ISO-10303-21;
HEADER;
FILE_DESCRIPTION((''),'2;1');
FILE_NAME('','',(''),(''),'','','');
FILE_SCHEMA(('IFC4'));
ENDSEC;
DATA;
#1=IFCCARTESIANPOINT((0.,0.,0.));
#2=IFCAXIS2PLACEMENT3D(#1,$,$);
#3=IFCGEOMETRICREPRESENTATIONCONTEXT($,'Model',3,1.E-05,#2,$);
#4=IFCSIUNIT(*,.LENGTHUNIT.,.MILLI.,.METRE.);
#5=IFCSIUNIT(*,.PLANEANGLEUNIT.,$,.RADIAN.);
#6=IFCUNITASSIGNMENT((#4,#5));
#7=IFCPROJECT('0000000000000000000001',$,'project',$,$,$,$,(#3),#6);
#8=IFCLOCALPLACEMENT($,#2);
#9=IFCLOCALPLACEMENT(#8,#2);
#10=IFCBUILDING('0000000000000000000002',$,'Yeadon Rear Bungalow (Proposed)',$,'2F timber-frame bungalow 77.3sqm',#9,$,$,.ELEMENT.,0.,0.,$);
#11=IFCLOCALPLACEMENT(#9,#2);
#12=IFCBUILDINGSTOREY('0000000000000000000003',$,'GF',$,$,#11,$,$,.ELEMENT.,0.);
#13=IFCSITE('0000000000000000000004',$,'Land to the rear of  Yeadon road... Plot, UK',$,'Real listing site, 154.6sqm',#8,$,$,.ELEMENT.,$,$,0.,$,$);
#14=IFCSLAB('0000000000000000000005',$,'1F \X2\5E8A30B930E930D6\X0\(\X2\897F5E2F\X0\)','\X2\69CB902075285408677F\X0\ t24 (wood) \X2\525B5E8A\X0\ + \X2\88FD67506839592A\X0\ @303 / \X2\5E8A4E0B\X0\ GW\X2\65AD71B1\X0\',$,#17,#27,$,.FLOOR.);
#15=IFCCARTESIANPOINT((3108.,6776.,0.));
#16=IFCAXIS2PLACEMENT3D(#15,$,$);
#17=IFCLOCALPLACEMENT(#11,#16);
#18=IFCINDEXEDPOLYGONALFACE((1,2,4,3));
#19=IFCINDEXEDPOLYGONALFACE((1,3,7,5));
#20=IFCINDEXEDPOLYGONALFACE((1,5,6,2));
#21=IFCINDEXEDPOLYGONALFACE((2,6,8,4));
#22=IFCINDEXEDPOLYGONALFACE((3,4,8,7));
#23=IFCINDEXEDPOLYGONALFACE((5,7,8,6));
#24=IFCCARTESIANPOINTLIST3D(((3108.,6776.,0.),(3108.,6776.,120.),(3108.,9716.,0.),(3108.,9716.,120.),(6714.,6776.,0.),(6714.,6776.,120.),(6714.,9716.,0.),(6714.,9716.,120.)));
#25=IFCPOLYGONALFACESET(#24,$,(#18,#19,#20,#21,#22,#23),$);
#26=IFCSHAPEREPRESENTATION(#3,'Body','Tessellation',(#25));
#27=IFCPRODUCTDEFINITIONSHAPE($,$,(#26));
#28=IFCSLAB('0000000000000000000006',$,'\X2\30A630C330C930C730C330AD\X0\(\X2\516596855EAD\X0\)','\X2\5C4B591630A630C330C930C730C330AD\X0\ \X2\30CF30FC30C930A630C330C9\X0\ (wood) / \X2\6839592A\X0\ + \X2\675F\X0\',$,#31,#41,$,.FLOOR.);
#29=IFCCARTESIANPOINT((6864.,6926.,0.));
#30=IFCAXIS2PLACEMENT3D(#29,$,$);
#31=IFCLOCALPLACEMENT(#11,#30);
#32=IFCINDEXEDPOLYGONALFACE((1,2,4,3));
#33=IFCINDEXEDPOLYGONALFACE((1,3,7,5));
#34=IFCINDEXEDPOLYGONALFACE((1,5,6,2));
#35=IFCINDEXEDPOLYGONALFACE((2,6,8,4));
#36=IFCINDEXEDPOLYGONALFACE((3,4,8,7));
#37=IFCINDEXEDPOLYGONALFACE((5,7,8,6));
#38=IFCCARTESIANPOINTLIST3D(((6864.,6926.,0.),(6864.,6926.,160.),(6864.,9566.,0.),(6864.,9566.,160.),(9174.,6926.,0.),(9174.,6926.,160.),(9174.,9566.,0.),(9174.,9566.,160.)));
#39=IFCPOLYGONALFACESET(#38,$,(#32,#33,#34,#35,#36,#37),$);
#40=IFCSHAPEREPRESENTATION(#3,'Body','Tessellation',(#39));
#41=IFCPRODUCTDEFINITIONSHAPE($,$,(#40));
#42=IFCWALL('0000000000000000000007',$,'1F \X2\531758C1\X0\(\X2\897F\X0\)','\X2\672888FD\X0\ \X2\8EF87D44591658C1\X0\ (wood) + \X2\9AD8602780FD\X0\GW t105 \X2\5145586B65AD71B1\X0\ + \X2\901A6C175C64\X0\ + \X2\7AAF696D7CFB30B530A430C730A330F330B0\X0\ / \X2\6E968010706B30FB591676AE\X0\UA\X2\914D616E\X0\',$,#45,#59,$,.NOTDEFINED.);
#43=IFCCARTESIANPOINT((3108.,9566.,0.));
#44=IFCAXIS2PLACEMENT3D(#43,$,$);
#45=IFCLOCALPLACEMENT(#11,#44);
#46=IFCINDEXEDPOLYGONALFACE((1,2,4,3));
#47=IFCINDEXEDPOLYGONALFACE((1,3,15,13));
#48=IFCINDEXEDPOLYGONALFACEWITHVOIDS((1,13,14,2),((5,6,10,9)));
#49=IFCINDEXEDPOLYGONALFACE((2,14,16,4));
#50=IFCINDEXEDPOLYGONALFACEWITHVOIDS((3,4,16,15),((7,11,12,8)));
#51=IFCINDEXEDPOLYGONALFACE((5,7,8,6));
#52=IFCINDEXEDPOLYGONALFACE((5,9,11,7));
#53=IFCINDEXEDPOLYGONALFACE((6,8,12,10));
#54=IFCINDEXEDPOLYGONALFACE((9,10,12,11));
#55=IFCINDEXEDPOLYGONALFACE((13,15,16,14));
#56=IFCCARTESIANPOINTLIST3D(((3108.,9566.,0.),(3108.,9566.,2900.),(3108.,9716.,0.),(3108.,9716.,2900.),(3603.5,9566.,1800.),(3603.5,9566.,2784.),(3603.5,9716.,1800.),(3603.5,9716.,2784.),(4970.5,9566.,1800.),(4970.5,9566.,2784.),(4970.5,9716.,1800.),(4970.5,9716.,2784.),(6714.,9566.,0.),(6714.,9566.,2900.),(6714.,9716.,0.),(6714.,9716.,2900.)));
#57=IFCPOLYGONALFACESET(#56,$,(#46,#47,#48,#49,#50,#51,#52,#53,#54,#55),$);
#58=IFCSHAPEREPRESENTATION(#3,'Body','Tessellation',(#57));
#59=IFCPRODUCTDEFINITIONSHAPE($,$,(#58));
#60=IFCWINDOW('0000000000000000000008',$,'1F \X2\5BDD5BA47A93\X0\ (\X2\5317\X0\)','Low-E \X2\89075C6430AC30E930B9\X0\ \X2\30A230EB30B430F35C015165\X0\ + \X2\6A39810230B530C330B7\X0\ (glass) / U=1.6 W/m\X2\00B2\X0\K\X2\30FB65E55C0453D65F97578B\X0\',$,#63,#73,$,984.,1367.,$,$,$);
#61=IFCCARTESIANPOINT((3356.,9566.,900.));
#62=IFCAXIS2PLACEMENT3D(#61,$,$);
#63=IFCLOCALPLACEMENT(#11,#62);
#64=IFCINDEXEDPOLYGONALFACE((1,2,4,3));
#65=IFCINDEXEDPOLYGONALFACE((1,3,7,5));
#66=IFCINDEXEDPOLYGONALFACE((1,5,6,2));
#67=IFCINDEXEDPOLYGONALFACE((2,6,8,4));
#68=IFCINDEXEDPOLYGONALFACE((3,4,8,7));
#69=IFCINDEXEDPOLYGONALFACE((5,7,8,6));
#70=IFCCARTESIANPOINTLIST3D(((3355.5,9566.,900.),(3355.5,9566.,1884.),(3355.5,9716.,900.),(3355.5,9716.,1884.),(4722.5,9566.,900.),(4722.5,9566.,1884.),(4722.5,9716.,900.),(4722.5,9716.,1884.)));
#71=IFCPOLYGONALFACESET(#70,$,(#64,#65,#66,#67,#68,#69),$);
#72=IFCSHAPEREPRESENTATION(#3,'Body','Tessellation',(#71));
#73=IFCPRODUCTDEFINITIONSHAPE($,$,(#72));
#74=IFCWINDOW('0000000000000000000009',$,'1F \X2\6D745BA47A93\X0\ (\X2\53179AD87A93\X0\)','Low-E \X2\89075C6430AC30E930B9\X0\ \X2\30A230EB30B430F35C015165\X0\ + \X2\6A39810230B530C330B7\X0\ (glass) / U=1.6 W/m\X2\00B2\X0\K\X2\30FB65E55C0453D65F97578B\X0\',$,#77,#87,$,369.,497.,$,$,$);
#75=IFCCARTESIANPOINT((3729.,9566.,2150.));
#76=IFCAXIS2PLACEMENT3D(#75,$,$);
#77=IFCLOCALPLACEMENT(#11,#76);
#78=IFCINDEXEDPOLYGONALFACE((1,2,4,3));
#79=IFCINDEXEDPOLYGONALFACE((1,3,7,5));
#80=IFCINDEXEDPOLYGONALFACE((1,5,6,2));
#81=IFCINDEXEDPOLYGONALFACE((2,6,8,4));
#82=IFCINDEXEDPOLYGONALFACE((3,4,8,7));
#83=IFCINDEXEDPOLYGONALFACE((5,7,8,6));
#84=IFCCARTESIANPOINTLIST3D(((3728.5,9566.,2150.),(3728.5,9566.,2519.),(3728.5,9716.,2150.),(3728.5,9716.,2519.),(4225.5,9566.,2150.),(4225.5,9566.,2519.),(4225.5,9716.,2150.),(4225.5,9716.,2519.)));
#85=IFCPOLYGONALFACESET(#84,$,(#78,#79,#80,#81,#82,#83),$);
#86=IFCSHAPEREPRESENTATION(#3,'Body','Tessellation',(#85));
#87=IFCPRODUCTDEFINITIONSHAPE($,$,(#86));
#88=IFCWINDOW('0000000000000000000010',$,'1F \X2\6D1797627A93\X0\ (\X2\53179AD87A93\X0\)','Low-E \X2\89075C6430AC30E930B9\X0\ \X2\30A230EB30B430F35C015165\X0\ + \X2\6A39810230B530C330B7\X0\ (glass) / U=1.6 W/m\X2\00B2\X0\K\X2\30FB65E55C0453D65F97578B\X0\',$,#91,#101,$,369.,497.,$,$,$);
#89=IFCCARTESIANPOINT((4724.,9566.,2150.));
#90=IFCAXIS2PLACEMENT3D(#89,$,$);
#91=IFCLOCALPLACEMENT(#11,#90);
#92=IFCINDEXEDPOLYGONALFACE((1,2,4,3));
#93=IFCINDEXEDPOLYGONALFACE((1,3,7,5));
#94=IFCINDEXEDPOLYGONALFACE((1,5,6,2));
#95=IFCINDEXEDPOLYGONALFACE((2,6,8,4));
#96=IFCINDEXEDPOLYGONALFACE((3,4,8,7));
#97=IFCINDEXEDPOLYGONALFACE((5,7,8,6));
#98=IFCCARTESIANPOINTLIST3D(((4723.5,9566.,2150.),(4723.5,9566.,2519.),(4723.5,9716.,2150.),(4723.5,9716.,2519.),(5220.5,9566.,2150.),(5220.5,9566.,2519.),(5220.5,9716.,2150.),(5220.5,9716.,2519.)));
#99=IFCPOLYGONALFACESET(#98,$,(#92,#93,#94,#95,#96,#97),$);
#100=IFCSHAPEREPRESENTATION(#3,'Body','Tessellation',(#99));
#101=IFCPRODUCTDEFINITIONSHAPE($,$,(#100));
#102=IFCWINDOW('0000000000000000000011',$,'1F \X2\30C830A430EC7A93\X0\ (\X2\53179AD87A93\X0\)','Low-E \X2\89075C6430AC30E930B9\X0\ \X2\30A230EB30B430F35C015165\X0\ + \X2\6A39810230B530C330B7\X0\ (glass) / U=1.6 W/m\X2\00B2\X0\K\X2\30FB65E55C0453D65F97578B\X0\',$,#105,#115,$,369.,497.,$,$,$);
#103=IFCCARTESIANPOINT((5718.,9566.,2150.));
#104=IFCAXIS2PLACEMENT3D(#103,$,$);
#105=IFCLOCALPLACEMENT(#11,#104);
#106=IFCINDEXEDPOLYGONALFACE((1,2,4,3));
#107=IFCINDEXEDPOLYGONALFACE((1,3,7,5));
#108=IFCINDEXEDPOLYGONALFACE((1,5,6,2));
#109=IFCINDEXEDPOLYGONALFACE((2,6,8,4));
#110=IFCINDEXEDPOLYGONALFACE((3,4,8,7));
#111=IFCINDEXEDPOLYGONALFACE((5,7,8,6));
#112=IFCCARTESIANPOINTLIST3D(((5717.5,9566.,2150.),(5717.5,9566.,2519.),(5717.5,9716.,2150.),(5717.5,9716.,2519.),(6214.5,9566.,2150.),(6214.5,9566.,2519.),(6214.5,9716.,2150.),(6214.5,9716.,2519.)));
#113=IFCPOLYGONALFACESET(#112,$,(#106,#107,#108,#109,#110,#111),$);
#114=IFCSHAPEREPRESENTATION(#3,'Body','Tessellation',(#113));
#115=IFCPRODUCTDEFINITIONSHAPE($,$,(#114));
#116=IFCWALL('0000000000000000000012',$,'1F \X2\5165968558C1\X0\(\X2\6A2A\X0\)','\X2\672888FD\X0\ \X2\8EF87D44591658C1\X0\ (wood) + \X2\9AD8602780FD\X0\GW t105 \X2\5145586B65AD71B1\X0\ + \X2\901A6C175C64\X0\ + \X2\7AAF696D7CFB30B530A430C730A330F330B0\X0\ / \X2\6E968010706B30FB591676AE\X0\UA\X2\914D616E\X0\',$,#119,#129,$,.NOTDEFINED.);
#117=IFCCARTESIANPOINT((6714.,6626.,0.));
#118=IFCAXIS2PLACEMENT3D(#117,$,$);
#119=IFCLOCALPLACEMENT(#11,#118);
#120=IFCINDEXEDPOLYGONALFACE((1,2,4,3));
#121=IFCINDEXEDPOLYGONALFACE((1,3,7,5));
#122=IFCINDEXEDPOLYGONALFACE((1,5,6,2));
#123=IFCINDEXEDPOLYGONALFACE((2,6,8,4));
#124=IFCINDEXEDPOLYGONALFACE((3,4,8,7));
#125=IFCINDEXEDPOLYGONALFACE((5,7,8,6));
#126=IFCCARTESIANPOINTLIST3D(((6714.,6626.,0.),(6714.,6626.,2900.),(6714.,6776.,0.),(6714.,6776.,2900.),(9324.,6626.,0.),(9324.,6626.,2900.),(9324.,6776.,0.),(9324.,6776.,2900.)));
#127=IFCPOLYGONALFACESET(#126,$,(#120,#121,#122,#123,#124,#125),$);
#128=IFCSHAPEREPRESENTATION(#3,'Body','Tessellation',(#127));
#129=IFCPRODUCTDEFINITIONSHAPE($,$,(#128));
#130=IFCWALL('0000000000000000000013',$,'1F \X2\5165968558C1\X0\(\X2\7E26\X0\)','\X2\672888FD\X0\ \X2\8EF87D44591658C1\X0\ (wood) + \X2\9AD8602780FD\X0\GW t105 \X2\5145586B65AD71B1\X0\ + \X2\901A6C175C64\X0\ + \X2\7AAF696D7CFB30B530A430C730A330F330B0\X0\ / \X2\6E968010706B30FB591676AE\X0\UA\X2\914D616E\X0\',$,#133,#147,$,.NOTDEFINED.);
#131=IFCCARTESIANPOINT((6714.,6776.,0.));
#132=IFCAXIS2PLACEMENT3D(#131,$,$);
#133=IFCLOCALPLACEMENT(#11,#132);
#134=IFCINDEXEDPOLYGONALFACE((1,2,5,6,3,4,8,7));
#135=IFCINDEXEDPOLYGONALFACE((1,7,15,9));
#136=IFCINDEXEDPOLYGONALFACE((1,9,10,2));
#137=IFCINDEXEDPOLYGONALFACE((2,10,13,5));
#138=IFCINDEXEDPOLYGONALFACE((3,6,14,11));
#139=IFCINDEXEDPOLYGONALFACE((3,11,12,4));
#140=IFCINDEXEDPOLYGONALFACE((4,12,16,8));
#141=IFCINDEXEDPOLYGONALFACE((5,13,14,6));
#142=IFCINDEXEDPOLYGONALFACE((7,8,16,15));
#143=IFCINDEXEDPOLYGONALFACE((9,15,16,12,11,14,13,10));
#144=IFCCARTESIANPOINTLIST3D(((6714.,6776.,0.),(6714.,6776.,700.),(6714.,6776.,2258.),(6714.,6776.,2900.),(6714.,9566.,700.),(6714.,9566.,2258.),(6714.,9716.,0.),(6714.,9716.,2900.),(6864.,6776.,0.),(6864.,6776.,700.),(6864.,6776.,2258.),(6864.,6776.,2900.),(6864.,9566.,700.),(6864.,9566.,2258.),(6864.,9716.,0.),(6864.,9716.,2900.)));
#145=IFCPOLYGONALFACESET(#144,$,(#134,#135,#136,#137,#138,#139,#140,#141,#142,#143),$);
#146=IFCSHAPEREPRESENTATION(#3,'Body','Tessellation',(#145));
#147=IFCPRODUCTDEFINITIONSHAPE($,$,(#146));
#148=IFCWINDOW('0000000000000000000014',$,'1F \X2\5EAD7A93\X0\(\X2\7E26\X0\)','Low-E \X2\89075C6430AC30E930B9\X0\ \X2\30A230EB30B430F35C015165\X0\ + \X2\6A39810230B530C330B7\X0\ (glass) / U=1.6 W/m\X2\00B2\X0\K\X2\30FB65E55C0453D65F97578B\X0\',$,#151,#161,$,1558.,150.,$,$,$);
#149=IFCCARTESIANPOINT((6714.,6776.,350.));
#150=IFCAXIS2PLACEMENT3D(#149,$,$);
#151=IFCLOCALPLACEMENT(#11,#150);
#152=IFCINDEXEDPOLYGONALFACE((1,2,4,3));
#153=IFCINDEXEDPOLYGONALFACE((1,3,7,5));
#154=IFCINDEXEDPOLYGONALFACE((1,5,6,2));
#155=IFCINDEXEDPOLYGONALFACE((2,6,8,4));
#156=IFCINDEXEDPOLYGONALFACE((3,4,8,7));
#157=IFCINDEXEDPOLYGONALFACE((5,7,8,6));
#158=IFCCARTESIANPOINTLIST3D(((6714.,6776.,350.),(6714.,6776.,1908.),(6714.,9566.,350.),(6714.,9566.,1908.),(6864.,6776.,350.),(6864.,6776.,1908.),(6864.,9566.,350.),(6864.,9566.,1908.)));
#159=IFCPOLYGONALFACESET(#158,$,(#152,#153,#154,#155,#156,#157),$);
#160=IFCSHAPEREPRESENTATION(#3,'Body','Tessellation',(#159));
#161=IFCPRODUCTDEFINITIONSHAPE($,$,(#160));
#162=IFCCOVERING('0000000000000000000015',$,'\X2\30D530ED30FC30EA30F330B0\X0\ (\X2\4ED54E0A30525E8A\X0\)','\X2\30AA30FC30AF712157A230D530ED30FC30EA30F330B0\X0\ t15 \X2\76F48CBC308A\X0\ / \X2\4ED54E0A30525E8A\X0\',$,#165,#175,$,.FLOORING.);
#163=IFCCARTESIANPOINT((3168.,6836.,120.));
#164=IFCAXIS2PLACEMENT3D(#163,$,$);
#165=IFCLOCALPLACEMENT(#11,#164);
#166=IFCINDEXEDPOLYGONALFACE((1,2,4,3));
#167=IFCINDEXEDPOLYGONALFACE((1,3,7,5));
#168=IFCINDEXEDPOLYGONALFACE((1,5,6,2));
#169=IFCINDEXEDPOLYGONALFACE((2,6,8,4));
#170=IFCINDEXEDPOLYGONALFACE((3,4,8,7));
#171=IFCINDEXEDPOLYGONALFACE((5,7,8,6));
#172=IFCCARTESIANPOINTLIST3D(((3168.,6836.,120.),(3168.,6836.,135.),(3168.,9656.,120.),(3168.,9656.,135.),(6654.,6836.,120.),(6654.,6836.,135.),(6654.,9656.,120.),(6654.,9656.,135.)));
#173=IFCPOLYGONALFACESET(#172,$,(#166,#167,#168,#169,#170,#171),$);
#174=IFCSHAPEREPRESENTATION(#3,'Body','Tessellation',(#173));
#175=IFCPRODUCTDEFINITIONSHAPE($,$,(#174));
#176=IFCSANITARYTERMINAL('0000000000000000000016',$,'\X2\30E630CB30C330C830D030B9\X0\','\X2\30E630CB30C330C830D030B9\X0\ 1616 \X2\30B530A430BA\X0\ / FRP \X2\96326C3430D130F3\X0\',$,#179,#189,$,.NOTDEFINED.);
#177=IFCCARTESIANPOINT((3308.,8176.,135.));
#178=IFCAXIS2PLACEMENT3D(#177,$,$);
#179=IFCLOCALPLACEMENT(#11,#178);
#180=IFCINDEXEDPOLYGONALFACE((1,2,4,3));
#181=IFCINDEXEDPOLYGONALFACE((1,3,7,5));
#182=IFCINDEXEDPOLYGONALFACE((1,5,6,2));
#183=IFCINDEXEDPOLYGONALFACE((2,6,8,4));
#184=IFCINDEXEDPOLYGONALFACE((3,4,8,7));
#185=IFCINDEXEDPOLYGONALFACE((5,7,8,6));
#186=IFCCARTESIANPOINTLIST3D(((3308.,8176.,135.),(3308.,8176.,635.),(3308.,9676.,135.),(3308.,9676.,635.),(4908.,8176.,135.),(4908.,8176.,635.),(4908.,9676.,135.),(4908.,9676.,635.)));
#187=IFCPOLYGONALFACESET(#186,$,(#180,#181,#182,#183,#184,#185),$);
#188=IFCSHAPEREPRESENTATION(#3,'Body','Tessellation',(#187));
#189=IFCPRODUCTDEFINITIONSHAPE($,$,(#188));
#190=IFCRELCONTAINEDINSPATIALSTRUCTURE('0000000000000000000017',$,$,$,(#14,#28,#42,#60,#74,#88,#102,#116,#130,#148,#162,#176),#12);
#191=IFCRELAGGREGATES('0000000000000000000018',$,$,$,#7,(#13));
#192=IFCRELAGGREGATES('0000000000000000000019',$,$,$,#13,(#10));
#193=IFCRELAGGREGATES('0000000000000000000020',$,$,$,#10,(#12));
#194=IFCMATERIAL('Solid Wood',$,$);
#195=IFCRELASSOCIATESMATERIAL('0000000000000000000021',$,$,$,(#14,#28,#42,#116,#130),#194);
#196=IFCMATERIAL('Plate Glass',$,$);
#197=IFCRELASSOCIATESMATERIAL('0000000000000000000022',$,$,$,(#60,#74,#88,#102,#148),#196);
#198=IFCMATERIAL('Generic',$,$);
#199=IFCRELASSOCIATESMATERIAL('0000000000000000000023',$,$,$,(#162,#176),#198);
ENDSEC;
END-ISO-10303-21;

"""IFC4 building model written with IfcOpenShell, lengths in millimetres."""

from ifc_helpers import new_model, si_unit, frame, frame_2d, origin, place, context, project, spatial, rectangle, extrude, material, element, fill, save


model = new_model("IFC4")

# Units and contexts
model_context = context("Model", 3, precision=1e-05, world=origin())
ifc_project = project(units=[si_unit("LENGTHUNIT", "METRE", prefix="MILLI"), si_unit("PLANEANGLEUNIT", "RADIAN")], contexts=[model_context])

# Site, building, storey
site_placement = place(None, origin())
site = spatial("IfcSite", under=ifc_project, at=site_placement, Name="Land to the rear of  Yeadon road... Plot, UK", ObjectType="Real listing site, 154.6sqm", CompositionType="ELEMENT", RefElevation=0.0)
building_placement = place(site_placement, origin())
building = spatial("IfcBuilding", under=site, at=building_placement, Name="Yeadon Rear Bungalow (Proposed)", ObjectType="2F timber-frame bungalow 77.3sqm", CompositionType="ELEMENT", ElevationOfRefHeight=0.0, ElevationOfTerrain=0.0)
storey_placement = place(building_placement, origin())
storey = spatial("IfcBuildingStorey", under=building, at=storey_placement, Name="GF", CompositionType="ELEMENT", Elevation=0.0)

# Slabs
ifc_material_1 = material(Name="Solid Wood")
slab_1_placement = place(storey_placement, frame((3108.0, 6776.0, 0.0)))
element("IfcSlab", 1, at=slab_1_placement, inside=storey, material=ifc_material_1, Name="1F 床スラブ(西帯)", Description="構造用合板 t24 (wood) 剛床 + 製材根太 @303 / 床下 GW断熱", PredefinedType="FLOOR", context=model_context, shape_type="SweptSolid", body=[
    extrude(rectangle(XDim=3606.0, YDim=2940.0, at=frame_2d((1803.0, 1470.0))), frame((3108.0, 6776.0, 0.0)), (0.0, 0.0, 1.0), 120.0),
])
slab_2_placement = place(storey_placement, frame((6864.0, 6926.0, 0.0)))
element("IfcSlab", 2, at=slab_2_placement, inside=storey, material=ifc_material_1, Name="ウッドデッキ(入隅庭)", Description="屋外ウッドデッキ ハードウッド (wood) / 根太 + 束", PredefinedType="FLOOR", context=model_context, shape_type="SweptSolid", body=[
    extrude(rectangle(XDim=2310.0, YDim=2640.0, at=frame_2d((1155.0, 1320.0))), frame((6864.0, 6926.0, 0.0)), (0.0, 0.0, 1.0), 160.0),
])

# Wall, openings, windows
wall_1_placement = place(storey_placement, frame((3108.0, 9566.0, 0.0)))
wall_1 = element("IfcWall", 3, at=wall_1_placement, inside=storey, material=ifc_material_1, Name="1F 北壁(西)", Description="木製 軸組外壁 (wood) + 高性能GW t105 充填断熱 + 通気層 + 窯業系サイディング / 準耐火・外皮UA配慮", PredefinedType="NOTDEFINED", context=model_context, shape_type="SweptSolid", body=[
    extrude(rectangle(XDim=3606.0, YDim=150.0, at=frame_2d((1803.0, 75.0))), frame((3108.0, 9566.0, 0.0)), (0.0, 0.0, 1.0), 2900.0),
])
opening_1_placement = place(storey_placement, frame((3356.0, 9566.0, 900.0)))
opening_1 = element("IfcOpeningElement", 4, at=opening_1_placement, cuts=wall_1, PredefinedType="NOTDEFINED", context=model_context, shape_type="SweptSolid", body=[
    extrude(rectangle(XDim=1367.0, YDim=150.0, at=frame_2d((683.0, 75.0))), frame((3356.0, 9566.0, 900.0)), (0.0, 0.0, 1.0), 984.0),
])
opening_2_placement = place(storey_placement, frame((3729.0, 9566.0, 2150.0)))
opening_2 = element("IfcOpeningElement", 5, at=opening_2_placement, cuts=wall_1, PredefinedType="NOTDEFINED", context=model_context, shape_type="SweptSolid", body=[
    extrude(rectangle(XDim=497.0, YDim=150.0, at=frame_2d((248.0, 75.0))), frame((3729.0, 9566.0, 2150.0)), (0.0, 0.0, 1.0), 369.0),
])
opening_3_placement = place(storey_placement, frame((4724.0, 9566.0, 2150.0)))
opening_3 = element("IfcOpeningElement", 6, at=opening_3_placement, cuts=wall_1, PredefinedType="NOTDEFINED", context=model_context, shape_type="SweptSolid", body=[
    extrude(rectangle(XDim=497.0, YDim=150.0, at=frame_2d((248.0, 75.0))), frame((4724.0, 9566.0, 2150.0)), (0.0, 0.0, 1.0), 369.0),
])
opening_4_placement = place(storey_placement, frame((5718.0, 9566.0, 2150.0)))
opening_4 = element("IfcOpeningElement", 7, at=opening_4_placement, cuts=wall_1, PredefinedType="NOTDEFINED", context=model_context, shape_type="SweptSolid", body=[
    extrude(rectangle(XDim=497.0, YDim=150.0, at=frame_2d((248.0, 75.0))), frame((5718.0, 9566.0, 2150.0)), (0.0, 0.0, 1.0), 369.0),
])
ifc_material_2 = material(Name="Plate Glass")
window_1_placement = place(storey_placement, frame((3356.0, 9566.0, 900.0)))
window_1 = element("IfcWindow", 8, at=window_1_placement, inside=storey, material=ifc_material_2, Name="1F 寝室窓 (北)", Description="Low-E 複層ガラス アルゴン封入 + 樹脂サッシ (glass) / U=1.6 W/m²K・日射取得型", OverallHeight=984.0, OverallWidth=1367.0, context=model_context, shape_type="SweptSolid", body=[
    extrude(rectangle(XDim=1367.0, YDim=150.0, at=frame_2d((683.0, 75.0))), frame((3356.0, 9566.0, 900.0)), (0.0, 0.0, 1.0), 984.0),
])
fill(opening_1, window_1)
window_2_placement = place(storey_placement, frame((3729.0, 9566.0, 2150.0)))
window_2 = element("IfcWindow", 9, at=window_2_placement, inside=storey, material=ifc_material_2, Name="1F 浴室窓 (北高窓)", Description="Low-E 複層ガラス アルゴン封入 + 樹脂サッシ (glass) / U=1.6 W/m²K・日射取得型", OverallHeight=369.0, OverallWidth=497.0, context=model_context, shape_type="SweptSolid", body=[
    extrude(rectangle(XDim=497.0, YDim=150.0, at=frame_2d((248.0, 75.0))), frame((3729.0, 9566.0, 2150.0)), (0.0, 0.0, 1.0), 369.0),
])
fill(opening_2, window_2)
window_3_placement = place(storey_placement, frame((4724.0, 9566.0, 2150.0)))
window_3 = element("IfcWindow", 10, at=window_3_placement, inside=storey, material=ifc_material_2, Name="1F 洗面窓 (北高窓)", Description="Low-E 複層ガラス アルゴン封入 + 樹脂サッシ (glass) / U=1.6 W/m²K・日射取得型", OverallHeight=369.0, OverallWidth=497.0, context=model_context, shape_type="SweptSolid", body=[
    extrude(rectangle(XDim=497.0, YDim=150.0, at=frame_2d((248.0, 75.0))), frame((4724.0, 9566.0, 2150.0)), (0.0, 0.0, 1.0), 369.0),
])
fill(opening_3, window_3)
window_4_placement = place(storey_placement, frame((5718.0, 9566.0, 2150.0)))
window_4 = element("IfcWindow", 11, at=window_4_placement, inside=storey, material=ifc_material_2, Name="1F トイレ窓 (北高窓)", Description="Low-E 複層ガラス アルゴン封入 + 樹脂サッシ (glass) / U=1.6 W/m²K・日射取得型", OverallHeight=369.0, OverallWidth=497.0, context=model_context, shape_type="SweptSolid", body=[
    extrude(rectangle(XDim=497.0, YDim=150.0, at=frame_2d((248.0, 75.0))), frame((5718.0, 9566.0, 2150.0)), (0.0, 0.0, 1.0), 369.0),
])
fill(opening_4, window_4)

# Wall
wall_2_placement = place(storey_placement, frame((6714.0, 6626.0, 0.0)))
element("IfcWall", 12, at=wall_2_placement, inside=storey, material=ifc_material_1, Name="1F 入隅壁(横)", Description="木製 軸組外壁 (wood) + 高性能GW t105 充填断熱 + 通気層 + 窯業系サイディング / 準耐火・外皮UA配慮", PredefinedType="NOTDEFINED", context=model_context, shape_type="SweptSolid", body=[
    extrude(rectangle(XDim=2610.0, YDim=150.0, at=frame_2d((1305.0, 75.0))), frame((6714.0, 6626.0, 0.0)), (0.0, 0.0, 1.0), 2900.0),
])

# Wall, opening, window
wall_3_placement = place(storey_placement, frame((6714.0, 6776.0, 0.0)))
wall_3 = element("IfcWall", 13, at=wall_3_placement, inside=storey, material=ifc_material_1, Name="1F 入隅壁(縦)", Description="木製 軸組外壁 (wood) + 高性能GW t105 充填断熱 + 通気層 + 窯業系サイディング / 準耐火・外皮UA配慮", PredefinedType="NOTDEFINED", context=model_context, shape_type="SweptSolid", body=[
    extrude(rectangle(XDim=150.0, YDim=2940.0, at=frame_2d((75.0, 1470.0))), frame((6714.0, 6776.0, 0.0)), (0.0, 0.0, 1.0), 2900.0),
])
opening_5_placement = place(storey_placement, frame((6714.0, 6776.0, 350.0)))
opening_5 = element("IfcOpeningElement", 14, at=opening_5_placement, cuts=wall_3, PredefinedType="NOTDEFINED", context=model_context, shape_type="SweptSolid", body=[
    extrude(rectangle(XDim=150.0, YDim=2790.0, at=frame_2d((75.0, 1395.0))), frame((6714.0, 6776.0, 350.0)), (0.0, 0.0, 1.0), 1558.0),
])
window_5_placement = place(storey_placement, frame((6714.0, 6776.0, 350.0)))
window_5 = element("IfcWindow", 15, at=window_5_placement, inside=storey, material=ifc_material_2, Name="1F 庭窓(縦)", Description="Low-E 複層ガラス アルゴン封入 + 樹脂サッシ (glass) / U=1.6 W/m²K・日射取得型", OverallHeight=1558.0, OverallWidth=150.0, context=model_context, shape_type="SweptSolid", body=[
    extrude(rectangle(XDim=150.0, YDim=2790.0, at=frame_2d((75.0, 1395.0))), frame((6714.0, 6776.0, 350.0)), (0.0, 0.0, 1.0), 1558.0),
])
fill(opening_5, window_5)

# Covering
ifc_material_3 = material(Name="Generic")
covering_placement = place(storey_placement, frame((3168.0, 6836.0, 120.0)))
element("IfcCovering", 16, at=covering_placement, inside=storey, material=ifc_material_3, Name="フローリング (仕上げ床)", Description="オーク無垢フローリング t15 直貼り / 仕上げ床", PredefinedType="FLOORING", context=model_context, shape_type="SweptSolid", body=[
    extrude(rectangle(XDim=3486.0, YDim=2820.0, at=frame_2d((1743.0, 1410.0))), frame((3168.0, 6836.0, 120.0)), (0.0, 0.0, 1.0), 15.0),
])

# Sanitary terminal
sanitary_terminal_1_placement = place(storey_placement, frame((3308.0, 8176.0, 135.0)))
element("IfcSanitaryTerminal", 17, at=sanitary_terminal_1_placement, inside=storey, material=ifc_material_3, Name="ユニットバス", Description="ユニットバス 1616 サイズ / FRP 防水パン", PredefinedType="NOTDEFINED", context=model_context, shape_type="SweptSolid", body=[
    extrude(rectangle(XDim=1600.0, YDim=1500.0, at=frame_2d((800.0, 750.0))), frame((3308.0, 8176.0, 135.0)), (0.0, 0.0, 1.0), 500.0),
])

save(model, "model.ifc")
